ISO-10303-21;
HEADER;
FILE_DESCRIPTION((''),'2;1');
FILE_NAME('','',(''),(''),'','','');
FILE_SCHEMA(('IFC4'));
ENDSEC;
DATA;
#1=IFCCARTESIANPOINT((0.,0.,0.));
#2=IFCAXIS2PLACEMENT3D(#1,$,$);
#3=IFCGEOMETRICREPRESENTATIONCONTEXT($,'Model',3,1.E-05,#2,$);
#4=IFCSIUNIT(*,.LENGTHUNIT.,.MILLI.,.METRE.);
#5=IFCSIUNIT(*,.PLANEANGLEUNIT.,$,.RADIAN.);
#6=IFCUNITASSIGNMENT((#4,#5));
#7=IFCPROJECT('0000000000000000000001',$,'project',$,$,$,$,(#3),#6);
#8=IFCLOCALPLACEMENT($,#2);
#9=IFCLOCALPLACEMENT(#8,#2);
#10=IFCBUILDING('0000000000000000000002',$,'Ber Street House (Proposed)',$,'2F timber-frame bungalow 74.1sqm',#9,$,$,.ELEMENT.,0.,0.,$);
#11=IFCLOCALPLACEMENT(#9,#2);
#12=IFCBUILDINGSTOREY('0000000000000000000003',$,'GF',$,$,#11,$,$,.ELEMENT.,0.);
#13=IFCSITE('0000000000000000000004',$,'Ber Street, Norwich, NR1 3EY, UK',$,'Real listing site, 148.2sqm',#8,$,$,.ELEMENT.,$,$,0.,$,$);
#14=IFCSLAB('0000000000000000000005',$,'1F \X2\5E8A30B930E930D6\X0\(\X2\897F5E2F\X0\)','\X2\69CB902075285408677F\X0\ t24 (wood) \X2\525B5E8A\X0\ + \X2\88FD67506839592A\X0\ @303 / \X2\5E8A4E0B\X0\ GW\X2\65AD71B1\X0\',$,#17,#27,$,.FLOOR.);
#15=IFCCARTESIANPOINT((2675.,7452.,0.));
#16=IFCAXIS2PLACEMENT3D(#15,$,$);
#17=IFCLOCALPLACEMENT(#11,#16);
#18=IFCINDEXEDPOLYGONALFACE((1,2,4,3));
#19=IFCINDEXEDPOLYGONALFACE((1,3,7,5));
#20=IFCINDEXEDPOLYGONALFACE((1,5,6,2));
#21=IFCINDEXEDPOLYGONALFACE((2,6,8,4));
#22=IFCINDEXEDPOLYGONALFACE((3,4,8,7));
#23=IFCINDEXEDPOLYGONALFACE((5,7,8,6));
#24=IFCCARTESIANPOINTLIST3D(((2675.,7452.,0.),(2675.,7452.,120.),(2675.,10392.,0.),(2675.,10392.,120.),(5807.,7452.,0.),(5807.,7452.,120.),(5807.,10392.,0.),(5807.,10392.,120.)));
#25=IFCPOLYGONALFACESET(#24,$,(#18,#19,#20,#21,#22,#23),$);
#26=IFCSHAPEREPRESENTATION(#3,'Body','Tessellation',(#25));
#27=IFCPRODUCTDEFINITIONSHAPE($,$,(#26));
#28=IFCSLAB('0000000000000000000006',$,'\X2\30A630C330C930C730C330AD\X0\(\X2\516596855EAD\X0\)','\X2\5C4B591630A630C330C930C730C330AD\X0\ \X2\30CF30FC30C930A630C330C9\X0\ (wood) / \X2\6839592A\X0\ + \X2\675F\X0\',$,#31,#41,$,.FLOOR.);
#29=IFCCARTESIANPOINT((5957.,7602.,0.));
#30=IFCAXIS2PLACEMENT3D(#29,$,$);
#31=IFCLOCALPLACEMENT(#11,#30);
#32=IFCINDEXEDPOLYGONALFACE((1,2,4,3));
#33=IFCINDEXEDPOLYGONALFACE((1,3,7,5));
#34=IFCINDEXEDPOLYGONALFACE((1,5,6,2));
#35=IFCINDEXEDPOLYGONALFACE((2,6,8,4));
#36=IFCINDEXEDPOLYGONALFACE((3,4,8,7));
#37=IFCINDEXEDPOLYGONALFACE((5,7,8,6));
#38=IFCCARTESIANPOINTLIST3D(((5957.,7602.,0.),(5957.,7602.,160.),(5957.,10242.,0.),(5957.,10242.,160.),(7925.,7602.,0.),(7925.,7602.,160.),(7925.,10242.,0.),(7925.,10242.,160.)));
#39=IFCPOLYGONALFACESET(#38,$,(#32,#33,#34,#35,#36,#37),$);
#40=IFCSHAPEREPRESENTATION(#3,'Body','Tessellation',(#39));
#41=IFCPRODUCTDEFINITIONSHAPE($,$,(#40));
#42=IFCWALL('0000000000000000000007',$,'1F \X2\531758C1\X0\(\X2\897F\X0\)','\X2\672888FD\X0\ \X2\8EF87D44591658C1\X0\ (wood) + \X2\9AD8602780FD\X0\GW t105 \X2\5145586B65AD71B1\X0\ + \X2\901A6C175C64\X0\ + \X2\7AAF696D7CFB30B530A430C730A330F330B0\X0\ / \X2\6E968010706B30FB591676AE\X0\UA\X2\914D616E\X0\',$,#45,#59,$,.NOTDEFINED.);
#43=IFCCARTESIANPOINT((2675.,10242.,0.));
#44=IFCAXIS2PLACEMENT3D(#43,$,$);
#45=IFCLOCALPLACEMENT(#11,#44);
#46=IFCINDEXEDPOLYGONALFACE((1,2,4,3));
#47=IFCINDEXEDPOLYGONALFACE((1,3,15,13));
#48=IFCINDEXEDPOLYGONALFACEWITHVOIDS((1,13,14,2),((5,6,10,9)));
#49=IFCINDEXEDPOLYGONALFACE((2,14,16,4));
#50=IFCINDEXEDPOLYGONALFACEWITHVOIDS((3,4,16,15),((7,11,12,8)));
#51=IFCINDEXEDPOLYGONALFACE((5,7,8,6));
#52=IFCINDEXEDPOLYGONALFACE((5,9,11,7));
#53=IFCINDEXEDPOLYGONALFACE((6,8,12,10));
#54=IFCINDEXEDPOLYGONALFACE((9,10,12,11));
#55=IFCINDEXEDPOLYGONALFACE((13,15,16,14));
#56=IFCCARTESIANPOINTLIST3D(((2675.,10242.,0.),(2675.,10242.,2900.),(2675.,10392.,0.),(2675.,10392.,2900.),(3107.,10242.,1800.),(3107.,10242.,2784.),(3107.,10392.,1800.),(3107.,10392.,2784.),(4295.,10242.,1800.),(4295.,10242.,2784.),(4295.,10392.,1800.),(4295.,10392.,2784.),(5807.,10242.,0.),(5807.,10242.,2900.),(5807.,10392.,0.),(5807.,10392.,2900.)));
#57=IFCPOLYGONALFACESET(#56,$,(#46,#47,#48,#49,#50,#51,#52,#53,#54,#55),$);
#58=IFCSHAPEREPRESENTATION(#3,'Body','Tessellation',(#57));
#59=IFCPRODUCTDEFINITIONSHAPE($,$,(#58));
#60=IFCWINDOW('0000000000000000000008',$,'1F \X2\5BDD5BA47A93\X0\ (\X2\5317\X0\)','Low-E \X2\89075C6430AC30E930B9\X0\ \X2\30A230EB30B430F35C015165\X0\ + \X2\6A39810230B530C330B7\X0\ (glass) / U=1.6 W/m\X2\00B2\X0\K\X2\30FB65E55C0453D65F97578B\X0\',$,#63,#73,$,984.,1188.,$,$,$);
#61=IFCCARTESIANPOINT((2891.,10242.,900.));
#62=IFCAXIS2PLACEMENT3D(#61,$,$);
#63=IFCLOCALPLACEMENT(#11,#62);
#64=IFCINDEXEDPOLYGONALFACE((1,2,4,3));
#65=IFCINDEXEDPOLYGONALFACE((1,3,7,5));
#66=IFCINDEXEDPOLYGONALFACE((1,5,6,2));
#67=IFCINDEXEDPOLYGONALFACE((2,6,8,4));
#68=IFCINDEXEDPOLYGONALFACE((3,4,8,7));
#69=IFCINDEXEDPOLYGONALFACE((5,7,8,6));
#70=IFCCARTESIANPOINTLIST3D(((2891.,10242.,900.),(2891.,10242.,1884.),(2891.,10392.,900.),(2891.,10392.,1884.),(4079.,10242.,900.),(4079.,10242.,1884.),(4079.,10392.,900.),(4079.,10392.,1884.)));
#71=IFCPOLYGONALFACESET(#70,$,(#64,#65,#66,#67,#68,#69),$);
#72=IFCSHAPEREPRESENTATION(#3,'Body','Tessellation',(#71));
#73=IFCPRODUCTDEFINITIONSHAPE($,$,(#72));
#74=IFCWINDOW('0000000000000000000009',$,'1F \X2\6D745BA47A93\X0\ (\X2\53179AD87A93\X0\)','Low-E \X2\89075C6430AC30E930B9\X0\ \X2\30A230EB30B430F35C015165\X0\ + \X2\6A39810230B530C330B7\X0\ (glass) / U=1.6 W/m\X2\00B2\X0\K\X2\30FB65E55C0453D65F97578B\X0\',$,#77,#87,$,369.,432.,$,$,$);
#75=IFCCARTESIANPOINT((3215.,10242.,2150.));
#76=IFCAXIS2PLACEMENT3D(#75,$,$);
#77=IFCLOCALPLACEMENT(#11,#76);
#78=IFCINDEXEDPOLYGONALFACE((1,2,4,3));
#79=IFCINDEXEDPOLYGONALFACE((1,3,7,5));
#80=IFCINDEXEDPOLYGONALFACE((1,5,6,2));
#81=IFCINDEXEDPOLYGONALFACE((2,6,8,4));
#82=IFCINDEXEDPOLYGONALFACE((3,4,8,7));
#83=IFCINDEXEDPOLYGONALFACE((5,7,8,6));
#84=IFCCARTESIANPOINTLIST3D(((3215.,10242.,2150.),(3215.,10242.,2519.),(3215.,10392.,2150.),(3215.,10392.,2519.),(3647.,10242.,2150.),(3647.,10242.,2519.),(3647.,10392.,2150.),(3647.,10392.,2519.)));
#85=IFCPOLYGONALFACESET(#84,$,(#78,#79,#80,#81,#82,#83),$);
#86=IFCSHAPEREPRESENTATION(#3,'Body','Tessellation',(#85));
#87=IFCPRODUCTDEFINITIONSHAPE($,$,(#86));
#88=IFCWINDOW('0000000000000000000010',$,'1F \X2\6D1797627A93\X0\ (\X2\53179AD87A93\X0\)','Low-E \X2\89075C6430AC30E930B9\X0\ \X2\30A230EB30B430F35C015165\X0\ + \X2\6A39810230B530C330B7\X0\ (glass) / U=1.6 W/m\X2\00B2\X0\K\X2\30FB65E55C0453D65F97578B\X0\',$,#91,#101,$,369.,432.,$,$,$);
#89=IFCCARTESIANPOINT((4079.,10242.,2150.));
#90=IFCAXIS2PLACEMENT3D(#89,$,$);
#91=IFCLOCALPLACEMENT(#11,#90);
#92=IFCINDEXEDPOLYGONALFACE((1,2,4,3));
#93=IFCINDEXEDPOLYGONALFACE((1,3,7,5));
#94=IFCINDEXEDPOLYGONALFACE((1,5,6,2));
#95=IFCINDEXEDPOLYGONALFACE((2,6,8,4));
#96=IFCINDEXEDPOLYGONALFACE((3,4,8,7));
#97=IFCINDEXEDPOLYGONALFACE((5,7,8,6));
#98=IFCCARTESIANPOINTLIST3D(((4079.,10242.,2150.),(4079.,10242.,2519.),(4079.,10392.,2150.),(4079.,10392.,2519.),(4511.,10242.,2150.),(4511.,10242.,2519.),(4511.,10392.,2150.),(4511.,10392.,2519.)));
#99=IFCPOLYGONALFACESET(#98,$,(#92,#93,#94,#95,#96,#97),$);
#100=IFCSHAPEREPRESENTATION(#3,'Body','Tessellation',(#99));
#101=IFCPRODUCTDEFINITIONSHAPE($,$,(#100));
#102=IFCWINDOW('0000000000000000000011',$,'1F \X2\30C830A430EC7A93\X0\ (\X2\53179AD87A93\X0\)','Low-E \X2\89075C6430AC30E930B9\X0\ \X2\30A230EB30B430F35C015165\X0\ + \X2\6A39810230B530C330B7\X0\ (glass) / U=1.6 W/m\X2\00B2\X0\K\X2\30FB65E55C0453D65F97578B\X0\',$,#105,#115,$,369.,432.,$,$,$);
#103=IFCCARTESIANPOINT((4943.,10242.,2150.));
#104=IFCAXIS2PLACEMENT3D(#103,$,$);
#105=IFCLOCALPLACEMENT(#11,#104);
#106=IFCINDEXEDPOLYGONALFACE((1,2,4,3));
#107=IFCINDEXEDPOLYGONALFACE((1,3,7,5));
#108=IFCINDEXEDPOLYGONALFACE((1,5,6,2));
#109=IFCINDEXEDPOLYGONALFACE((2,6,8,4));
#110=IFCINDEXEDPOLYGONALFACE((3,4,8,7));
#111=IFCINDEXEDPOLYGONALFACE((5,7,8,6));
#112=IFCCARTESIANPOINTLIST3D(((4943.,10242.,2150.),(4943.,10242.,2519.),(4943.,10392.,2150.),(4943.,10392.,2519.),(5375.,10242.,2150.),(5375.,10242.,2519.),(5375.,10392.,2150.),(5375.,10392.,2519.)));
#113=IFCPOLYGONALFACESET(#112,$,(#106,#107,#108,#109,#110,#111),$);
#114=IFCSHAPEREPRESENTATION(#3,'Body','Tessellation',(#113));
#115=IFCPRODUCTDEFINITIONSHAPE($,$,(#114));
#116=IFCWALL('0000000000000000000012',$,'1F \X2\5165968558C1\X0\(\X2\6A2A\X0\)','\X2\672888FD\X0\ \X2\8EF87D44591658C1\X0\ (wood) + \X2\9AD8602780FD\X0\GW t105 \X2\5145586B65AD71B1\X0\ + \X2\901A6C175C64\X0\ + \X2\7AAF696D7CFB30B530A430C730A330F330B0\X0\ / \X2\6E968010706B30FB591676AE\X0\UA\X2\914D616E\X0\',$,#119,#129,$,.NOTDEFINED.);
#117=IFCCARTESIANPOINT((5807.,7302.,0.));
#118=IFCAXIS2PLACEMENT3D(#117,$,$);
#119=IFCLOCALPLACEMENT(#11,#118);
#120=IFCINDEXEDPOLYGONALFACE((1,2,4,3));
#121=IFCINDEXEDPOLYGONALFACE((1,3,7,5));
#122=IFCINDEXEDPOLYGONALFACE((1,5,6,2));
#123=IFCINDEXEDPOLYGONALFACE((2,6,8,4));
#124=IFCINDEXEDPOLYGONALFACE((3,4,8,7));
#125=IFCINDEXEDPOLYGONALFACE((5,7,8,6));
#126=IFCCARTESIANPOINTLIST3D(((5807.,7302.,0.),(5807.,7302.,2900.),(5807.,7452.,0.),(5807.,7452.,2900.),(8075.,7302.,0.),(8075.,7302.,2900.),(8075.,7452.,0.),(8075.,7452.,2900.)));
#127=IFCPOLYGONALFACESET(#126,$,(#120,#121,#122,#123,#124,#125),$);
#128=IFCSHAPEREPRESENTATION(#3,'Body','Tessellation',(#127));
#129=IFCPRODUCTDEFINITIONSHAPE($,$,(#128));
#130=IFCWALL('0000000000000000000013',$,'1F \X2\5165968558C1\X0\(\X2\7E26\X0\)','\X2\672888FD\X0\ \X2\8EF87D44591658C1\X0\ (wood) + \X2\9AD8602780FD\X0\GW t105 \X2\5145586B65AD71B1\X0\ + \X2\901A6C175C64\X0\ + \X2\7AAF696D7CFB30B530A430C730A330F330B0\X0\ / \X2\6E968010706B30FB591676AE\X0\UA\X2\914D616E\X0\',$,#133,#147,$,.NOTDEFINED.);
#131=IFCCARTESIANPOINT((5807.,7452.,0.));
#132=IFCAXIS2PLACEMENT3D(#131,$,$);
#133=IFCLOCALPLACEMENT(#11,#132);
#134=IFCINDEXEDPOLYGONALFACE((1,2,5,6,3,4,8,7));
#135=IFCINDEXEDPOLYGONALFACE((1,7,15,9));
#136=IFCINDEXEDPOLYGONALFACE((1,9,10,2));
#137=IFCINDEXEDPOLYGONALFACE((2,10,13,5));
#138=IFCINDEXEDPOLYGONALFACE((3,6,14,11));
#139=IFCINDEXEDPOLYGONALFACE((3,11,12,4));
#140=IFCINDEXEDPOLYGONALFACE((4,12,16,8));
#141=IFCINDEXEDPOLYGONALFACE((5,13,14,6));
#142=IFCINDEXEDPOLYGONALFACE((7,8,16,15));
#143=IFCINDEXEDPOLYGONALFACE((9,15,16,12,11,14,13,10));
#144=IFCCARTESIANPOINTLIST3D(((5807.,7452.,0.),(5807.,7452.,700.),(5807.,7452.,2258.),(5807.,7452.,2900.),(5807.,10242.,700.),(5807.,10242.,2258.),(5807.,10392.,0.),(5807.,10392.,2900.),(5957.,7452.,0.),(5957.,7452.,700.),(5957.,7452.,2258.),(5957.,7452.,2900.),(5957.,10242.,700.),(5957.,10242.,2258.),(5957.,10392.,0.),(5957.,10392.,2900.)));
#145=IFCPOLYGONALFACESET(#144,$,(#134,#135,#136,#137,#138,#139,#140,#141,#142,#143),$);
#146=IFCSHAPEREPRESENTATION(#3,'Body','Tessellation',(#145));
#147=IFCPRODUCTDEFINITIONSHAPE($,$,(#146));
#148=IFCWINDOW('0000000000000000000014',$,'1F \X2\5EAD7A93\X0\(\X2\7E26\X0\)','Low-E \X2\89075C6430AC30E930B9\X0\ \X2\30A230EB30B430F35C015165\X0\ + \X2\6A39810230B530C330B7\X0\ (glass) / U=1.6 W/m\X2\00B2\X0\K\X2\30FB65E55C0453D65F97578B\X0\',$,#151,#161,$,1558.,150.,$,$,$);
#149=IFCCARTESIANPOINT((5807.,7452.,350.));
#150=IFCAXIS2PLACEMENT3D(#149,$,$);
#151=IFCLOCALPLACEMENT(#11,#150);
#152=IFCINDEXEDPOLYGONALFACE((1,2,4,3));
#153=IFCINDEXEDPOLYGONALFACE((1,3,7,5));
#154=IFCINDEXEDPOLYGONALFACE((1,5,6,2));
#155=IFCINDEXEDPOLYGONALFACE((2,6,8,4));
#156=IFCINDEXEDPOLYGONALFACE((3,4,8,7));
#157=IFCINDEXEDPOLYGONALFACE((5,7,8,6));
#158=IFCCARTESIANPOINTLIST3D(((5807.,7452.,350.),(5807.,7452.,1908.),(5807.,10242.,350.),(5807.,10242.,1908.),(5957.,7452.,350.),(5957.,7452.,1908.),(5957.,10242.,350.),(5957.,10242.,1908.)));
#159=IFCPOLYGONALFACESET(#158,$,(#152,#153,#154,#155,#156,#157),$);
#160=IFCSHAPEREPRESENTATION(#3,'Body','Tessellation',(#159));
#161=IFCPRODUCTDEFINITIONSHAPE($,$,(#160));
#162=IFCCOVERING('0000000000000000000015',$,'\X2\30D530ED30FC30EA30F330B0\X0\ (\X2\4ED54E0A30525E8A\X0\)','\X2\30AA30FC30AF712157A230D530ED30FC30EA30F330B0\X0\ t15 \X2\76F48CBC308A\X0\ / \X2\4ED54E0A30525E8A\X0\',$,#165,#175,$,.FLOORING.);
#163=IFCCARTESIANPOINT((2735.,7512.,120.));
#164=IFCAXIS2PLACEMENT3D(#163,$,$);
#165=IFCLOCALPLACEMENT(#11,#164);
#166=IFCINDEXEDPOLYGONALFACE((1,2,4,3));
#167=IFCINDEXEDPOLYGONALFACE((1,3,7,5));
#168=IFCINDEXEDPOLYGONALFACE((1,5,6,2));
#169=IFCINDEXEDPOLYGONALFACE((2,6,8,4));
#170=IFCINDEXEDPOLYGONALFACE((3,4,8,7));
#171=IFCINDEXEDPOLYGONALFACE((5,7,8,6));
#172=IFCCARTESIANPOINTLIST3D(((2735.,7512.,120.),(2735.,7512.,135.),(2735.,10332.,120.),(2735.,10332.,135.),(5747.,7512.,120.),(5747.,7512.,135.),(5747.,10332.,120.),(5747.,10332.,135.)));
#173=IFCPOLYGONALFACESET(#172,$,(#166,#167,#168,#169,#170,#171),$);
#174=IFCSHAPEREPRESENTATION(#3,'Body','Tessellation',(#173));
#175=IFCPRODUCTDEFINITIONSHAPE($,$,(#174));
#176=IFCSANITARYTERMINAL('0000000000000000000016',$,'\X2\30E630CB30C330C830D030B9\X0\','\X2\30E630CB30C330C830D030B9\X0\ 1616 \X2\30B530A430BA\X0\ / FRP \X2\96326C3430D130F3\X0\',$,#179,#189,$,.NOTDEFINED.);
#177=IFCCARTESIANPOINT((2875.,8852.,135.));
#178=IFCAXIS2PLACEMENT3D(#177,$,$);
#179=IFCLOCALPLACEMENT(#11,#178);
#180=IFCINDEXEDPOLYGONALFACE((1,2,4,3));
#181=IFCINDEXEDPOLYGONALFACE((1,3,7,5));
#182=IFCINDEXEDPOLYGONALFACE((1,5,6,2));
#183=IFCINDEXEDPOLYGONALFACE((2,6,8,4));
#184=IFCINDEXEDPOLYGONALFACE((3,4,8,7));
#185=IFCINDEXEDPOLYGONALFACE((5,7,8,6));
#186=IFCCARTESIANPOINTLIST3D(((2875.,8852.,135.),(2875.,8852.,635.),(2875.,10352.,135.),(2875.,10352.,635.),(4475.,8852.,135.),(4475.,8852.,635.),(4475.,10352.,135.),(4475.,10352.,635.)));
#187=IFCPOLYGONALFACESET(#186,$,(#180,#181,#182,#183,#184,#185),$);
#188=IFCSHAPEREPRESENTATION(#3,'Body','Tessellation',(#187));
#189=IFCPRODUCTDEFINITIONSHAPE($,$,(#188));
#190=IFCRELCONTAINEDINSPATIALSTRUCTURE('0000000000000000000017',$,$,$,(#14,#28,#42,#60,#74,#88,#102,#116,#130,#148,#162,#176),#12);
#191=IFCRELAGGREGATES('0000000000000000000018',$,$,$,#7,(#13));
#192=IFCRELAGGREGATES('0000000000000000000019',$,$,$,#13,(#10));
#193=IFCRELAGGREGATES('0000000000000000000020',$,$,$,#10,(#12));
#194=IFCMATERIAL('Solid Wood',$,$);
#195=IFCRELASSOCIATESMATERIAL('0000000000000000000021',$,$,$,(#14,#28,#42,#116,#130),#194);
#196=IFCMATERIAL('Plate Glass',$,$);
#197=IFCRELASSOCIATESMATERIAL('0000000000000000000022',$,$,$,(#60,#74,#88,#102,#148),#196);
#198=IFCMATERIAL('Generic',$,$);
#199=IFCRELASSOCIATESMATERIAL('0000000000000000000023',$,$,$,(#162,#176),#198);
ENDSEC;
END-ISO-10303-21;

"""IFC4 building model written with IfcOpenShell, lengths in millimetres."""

from ifc_helpers import new_model, si_unit, frame, frame_2d, origin, place, context, project, spatial, rectangle, extrude, material, element, fill, save


model = new_model("IFC4")

# Units and contexts
model_context = context("Model", 3, precision=1e-05, world=origin())
ifc_project = project(units=[si_unit("LENGTHUNIT", "METRE", prefix="MILLI"), si_unit("PLANEANGLEUNIT", "RADIAN")], contexts=[model_context])

# Site, building, storey
site_placement = place(None, origin())
site = spatial("IfcSite", under=ifc_project, at=site_placement, Name="Ber Street, Norwich, NR1 3EY, UK", ObjectType="Real listing site, 148.2sqm", CompositionType="ELEMENT", RefElevation=0.0)
building_placement = place(site_placement, origin())
building = spatial("IfcBuilding", under=site, at=building_placement, Name="Ber Street House (Proposed)", ObjectType="2F timber-frame bungalow 74.1sqm", CompositionType="ELEMENT", ElevationOfRefHeight=0.0, ElevationOfTerrain=0.0)
storey_placement = place(building_placement, origin())
storey = spatial("IfcBuildingStorey", under=building, at=storey_placement, Name="GF", CompositionType="ELEMENT", Elevation=0.0)

# Slabs
ifc_material_1 = material(Name="Solid Wood")
slab_1_placement = place(storey_placement, frame((2675.0, 7452.0, 0.0)))
element("IfcSlab", 1, at=slab_1_placement, inside=storey, material=ifc_material_1, Name="1F 床スラブ(西帯)", Description="構造用合板 t24 (wood) 剛床 + 製材根太 @303 / 床下 GW断熱", PredefinedType="FLOOR", context=model_context, shape_type="SweptSolid", body=[
    extrude(rectangle(XDim=3132.0, YDim=2940.0, at=frame_2d((1566.0, 1470.0))), frame((2675.0, 7452.0, 0.0)), (0.0, 0.0, 1.0), 120.0),
])
slab_2_placement = place(storey_placement, frame((5957.0, 7602.0, 0.0)))
element("IfcSlab", 2, at=slab_2_placement, inside=storey, material=ifc_material_1, Name="ウッドデッキ(入隅庭)", Description="屋外ウッドデッキ ハードウッド (wood) / 根太 + 束", PredefinedType="FLOOR", context=model_context, shape_type="SweptSolid", body=[
    extrude(rectangle(XDim=1968.0, YDim=2640.0, at=frame_2d((984.0, 1320.0))), frame((5957.0, 7602.0, 0.0)), (0.0, 0.0, 1.0), 160.0),
])

# Wall, openings, windows
wall_1_placement = place(storey_placement, frame((2675.0, 10242.0, 0.0)))
wall_1 = element("IfcWall", 3, at=wall_1_placement, inside=storey, material=ifc_material_1, Name="1F 北壁(西)", Description="木製 軸組外壁 (wood) + 高性能GW t105 充填断熱 + 通気層 + 窯業系サイディング / 準耐火・外皮UA配慮", PredefinedType="NOTDEFINED", context=model_context, shape_type="SweptSolid", body=[
    extrude(rectangle(XDim=3132.0, YDim=150.0, at=frame_2d((1566.0, 75.0))), frame((2675.0, 10242.0, 0.0)), (0.0, 0.0, 1.0), 2900.0),
])
opening_1_placement = place(storey_placement, frame((2891.0, 10242.0, 900.0)))
opening_1 = element("IfcOpeningElement", 4, at=opening_1_placement, cuts=wall_1, PredefinedType="NOTDEFINED", context=model_context, shape_type="SweptSolid", body=[
    extrude(rectangle(XDim=1188.0, YDim=150.0, at=frame_2d((594.0, 75.0))), frame((2891.0, 10242.0, 900.0)), (0.0, 0.0, 1.0), 984.0),
])
opening_2_placement = place(storey_placement, frame((3215.0, 10242.0, 2150.0)))
opening_2 = element("IfcOpeningElement", 5, at=opening_2_placement, cuts=wall_1, PredefinedType="NOTDEFINED", context=model_context, shape_type="SweptSolid", body=[
    extrude(rectangle(XDim=432.0, YDim=150.0, at=frame_2d((216.0, 75.0))), frame((3215.0, 10242.0, 2150.0)), (0.0, 0.0, 1.0), 369.0),
])
opening_3_placement = place(storey_placement, frame((4079.0, 10242.0, 2150.0)))
opening_3 = element("IfcOpeningElement", 6, at=opening_3_placement, cuts=wall_1, PredefinedType="NOTDEFINED", context=model_context, shape_type="SweptSolid", body=[
    extrude(rectangle(XDim=432.0, YDim=150.0, at=frame_2d((216.0, 75.0))), frame((4079.0, 10242.0, 2150.0)), (0.0, 0.0, 1.0), 369.0),
])
opening_4_placement = place(storey_placement, frame((4943.0, 10242.0, 2150.0)))
opening_4 = element("IfcOpeningElement", 7, at=opening_4_placement, cuts=wall_1, PredefinedType="NOTDEFINED", context=model_context, shape_type="SweptSolid", body=[
    extrude(rectangle(XDim=432.0, YDim=150.0, at=frame_2d((216.0, 75.0))), frame((4943.0, 10242.0, 2150.0)), (0.0, 0.0, 1.0), 369.0),
])
ifc_material_2 = material(Name="Plate Glass")
window_1_placement = place(storey_placement, frame((2891.0, 10242.0, 900.0)))
window_1 = element("IfcWindow", 8, at=window_1_placement, inside=storey, material=ifc_material_2, Name="1F 寝室窓 (北)", Description="Low-E 複層ガラス アルゴン封入 + 樹脂サッシ (glass) / U=1.6 W/m²K・日射取得型", OverallHeight=984.0, OverallWidth=1188.0, context=model_context, shape_type="SweptSolid", body=[
    extrude(rectangle(XDim=1188.0, YDim=150.0, at=frame_2d((594.0, 75.0))), frame((2891.0, 10242.0, 900.0)), (0.0, 0.0, 1.0), 984.0),
])
fill(opening_1, window_1)
window_2_placement = place(storey_placement, frame((3215.0, 10242.0, 2150.0)))
window_2 = element("IfcWindow", 9, at=window_2_placement, inside=storey, material=ifc_material_2, Name="1F 浴室窓 (北高窓)", Description="Low-E 複層ガラス アルゴン封入 + 樹脂サッシ (glass) / U=1.6 W/m²K・日射取得型", OverallHeight=369.0, OverallWidth=432.0, context=model_context, shape_type="SweptSolid", body=[
    extrude(rectangle(XDim=432.0, YDim=150.0, at=frame_2d((216.0, 75.0))), frame((3215.0, 10242.0, 2150.0)), (0.0, 0.0, 1.0), 369.0),
])
fill(opening_2, window_2)
window_3_placement = place(storey_placement, frame((4079.0, 10242.0, 2150.0)))
window_3 = element("IfcWindow", 10, at=window_3_placement, inside=storey, material=ifc_material_2, Name="1F 洗面窓 (北高窓)", Description="Low-E 複層ガラス アルゴン封入 + 樹脂サッシ (glass) / U=1.6 W/m²K・日射取得型", OverallHeight=369.0, OverallWidth=432.0, context=model_context, shape_type="SweptSolid", body=[
    extrude(rectangle(XDim=432.0, YDim=150.0, at=frame_2d((216.0, 75.0))), frame((4079.0, 10242.0, 2150.0)), (0.0, 0.0, 1.0), 369.0),
])
fill(opening_3, window_3)
window_4_placement = place(storey_placement, frame((4943.0, 10242.0, 2150.0)))
window_4 = element("IfcWindow", 11, at=window_4_placement, inside=storey, material=ifc_material_2, Name="1F トイレ窓 (北高窓)", Description="Low-E 複層ガラス アルゴン封入 + 樹脂サッシ (glass) / U=1.6 W/m²K・日射取得型", OverallHeight=369.0, OverallWidth=432.0, context=model_context, shape_type="SweptSolid", body=[
    extrude(rectangle(XDim=432.0, YDim=150.0, at=frame_2d((216.0, 75.0))), frame((4943.0, 10242.0, 2150.0)), (0.0, 0.0, 1.0), 369.0),
])
fill(opening_4, window_4)

# Wall
wall_2_placement = place(storey_placement, frame((5807.0, 7302.0, 0.0)))
element("IfcWall", 12, at=wall_2_placement, inside=storey, material=ifc_material_1, Name="1F 入隅壁(横)", Description="木製 軸組外壁 (wood) + 高性能GW t105 充填断熱 + 通気層 + 窯業系サイディング / 準耐火・外皮UA配慮", PredefinedType="NOTDEFINED", context=model_context, shape_type="SweptSolid", body=[
    extrude(rectangle(XDim=2268.0, YDim=150.0, at=frame_2d((1134.0, 75.0))), frame((5807.0, 7302.0, 0.0)), (0.0, 0.0, 1.0), 2900.0),
])

# Wall, opening, window
wall_3_placement = place(storey_placement, frame((5807.0, 7452.0, 0.0)))
wall_3 = element("IfcWall", 13, at=wall_3_placement, inside=storey, material=ifc_material_1, Name="1F 入隅壁(縦)", Description="木製 軸組外壁 (wood) + 高性能GW t105 充填断熱 + 通気層 + 窯業系サイディング / 準耐火・外皮UA配慮", PredefinedType="NOTDEFINED", context=model_context, shape_type="SweptSolid", body=[
    extrude(rectangle(XDim=150.0, YDim=2940.0, at=frame_2d((75.0, 1470.0))), frame((5807.0, 7452.0, 0.0)), (0.0, 0.0, 1.0), 2900.0),
])
opening_5_placement = place(storey_placement, frame((5807.0, 7452.0, 350.0)))
opening_5 = element("IfcOpeningElement", 14, at=opening_5_placement, cuts=wall_3, PredefinedType="NOTDEFINED", context=model_context, shape_type="SweptSolid", body=[
    extrude(rectangle(XDim=150.0, YDim=2790.0, at=frame_2d((75.0, 1395.0))), frame((5807.0, 7452.0, 350.0)), (0.0, 0.0, 1.0), 1558.0),
])
window_5_placement = place(storey_placement, frame((5807.0, 7452.0, 350.0)))
window_5 = element("IfcWindow", 15, at=window_5_placement, inside=storey, material=ifc_material_2, Name="1F 庭窓(縦)", Description="Low-E 複層ガラス アルゴン封入 + 樹脂サッシ (glass) / U=1.6 W/m²K・日射取得型", OverallHeight=1558.0, OverallWidth=150.0, context=model_context, shape_type="SweptSolid", body=[
    extrude(rectangle(XDim=150.0, YDim=2790.0, at=frame_2d((75.0, 1395.0))), frame((5807.0, 7452.0, 350.0)), (0.0, 0.0, 1.0), 1558.0),
])
fill(opening_5, window_5)

# Covering
ifc_material_3 = material(Name="Generic")
covering_placement = place(storey_placement, frame((2735.0, 7512.0, 120.0)))
element("IfcCovering", 16, at=covering_placement, inside=storey, material=ifc_material_3, Name="フローリング (仕上げ床)", Description="オーク無垢フローリング t15 直貼り / 仕上げ床", PredefinedType="FLOORING", context=model_context, shape_type="SweptSolid", body=[
    extrude(rectangle(XDim=3012.0, YDim=2820.0, at=frame_2d((1506.0, 1410.0))), frame((2735.0, 7512.0, 120.0)), (0.0, 0.0, 1.0), 15.0),
])

# Sanitary terminal
sanitary_terminal_1_placement = place(storey_placement, frame((2875.0, 8852.0, 135.0)))
element("IfcSanitaryTerminal", 17, at=sanitary_terminal_1_placement, inside=storey, material=ifc_material_3, Name="ユニットバス", Description="ユニットバス 1616 サイズ / FRP 防水パン", PredefinedType="NOTDEFINED", context=model_context, shape_type="SweptSolid", body=[
    extrude(rectangle(XDim=1600.0, YDim=1500.0, at=frame_2d((800.0, 750.0))), frame((2875.0, 8852.0, 135.0)), (0.0, 0.0, 1.0), 500.0),
])

save(model, "model.ifc")
